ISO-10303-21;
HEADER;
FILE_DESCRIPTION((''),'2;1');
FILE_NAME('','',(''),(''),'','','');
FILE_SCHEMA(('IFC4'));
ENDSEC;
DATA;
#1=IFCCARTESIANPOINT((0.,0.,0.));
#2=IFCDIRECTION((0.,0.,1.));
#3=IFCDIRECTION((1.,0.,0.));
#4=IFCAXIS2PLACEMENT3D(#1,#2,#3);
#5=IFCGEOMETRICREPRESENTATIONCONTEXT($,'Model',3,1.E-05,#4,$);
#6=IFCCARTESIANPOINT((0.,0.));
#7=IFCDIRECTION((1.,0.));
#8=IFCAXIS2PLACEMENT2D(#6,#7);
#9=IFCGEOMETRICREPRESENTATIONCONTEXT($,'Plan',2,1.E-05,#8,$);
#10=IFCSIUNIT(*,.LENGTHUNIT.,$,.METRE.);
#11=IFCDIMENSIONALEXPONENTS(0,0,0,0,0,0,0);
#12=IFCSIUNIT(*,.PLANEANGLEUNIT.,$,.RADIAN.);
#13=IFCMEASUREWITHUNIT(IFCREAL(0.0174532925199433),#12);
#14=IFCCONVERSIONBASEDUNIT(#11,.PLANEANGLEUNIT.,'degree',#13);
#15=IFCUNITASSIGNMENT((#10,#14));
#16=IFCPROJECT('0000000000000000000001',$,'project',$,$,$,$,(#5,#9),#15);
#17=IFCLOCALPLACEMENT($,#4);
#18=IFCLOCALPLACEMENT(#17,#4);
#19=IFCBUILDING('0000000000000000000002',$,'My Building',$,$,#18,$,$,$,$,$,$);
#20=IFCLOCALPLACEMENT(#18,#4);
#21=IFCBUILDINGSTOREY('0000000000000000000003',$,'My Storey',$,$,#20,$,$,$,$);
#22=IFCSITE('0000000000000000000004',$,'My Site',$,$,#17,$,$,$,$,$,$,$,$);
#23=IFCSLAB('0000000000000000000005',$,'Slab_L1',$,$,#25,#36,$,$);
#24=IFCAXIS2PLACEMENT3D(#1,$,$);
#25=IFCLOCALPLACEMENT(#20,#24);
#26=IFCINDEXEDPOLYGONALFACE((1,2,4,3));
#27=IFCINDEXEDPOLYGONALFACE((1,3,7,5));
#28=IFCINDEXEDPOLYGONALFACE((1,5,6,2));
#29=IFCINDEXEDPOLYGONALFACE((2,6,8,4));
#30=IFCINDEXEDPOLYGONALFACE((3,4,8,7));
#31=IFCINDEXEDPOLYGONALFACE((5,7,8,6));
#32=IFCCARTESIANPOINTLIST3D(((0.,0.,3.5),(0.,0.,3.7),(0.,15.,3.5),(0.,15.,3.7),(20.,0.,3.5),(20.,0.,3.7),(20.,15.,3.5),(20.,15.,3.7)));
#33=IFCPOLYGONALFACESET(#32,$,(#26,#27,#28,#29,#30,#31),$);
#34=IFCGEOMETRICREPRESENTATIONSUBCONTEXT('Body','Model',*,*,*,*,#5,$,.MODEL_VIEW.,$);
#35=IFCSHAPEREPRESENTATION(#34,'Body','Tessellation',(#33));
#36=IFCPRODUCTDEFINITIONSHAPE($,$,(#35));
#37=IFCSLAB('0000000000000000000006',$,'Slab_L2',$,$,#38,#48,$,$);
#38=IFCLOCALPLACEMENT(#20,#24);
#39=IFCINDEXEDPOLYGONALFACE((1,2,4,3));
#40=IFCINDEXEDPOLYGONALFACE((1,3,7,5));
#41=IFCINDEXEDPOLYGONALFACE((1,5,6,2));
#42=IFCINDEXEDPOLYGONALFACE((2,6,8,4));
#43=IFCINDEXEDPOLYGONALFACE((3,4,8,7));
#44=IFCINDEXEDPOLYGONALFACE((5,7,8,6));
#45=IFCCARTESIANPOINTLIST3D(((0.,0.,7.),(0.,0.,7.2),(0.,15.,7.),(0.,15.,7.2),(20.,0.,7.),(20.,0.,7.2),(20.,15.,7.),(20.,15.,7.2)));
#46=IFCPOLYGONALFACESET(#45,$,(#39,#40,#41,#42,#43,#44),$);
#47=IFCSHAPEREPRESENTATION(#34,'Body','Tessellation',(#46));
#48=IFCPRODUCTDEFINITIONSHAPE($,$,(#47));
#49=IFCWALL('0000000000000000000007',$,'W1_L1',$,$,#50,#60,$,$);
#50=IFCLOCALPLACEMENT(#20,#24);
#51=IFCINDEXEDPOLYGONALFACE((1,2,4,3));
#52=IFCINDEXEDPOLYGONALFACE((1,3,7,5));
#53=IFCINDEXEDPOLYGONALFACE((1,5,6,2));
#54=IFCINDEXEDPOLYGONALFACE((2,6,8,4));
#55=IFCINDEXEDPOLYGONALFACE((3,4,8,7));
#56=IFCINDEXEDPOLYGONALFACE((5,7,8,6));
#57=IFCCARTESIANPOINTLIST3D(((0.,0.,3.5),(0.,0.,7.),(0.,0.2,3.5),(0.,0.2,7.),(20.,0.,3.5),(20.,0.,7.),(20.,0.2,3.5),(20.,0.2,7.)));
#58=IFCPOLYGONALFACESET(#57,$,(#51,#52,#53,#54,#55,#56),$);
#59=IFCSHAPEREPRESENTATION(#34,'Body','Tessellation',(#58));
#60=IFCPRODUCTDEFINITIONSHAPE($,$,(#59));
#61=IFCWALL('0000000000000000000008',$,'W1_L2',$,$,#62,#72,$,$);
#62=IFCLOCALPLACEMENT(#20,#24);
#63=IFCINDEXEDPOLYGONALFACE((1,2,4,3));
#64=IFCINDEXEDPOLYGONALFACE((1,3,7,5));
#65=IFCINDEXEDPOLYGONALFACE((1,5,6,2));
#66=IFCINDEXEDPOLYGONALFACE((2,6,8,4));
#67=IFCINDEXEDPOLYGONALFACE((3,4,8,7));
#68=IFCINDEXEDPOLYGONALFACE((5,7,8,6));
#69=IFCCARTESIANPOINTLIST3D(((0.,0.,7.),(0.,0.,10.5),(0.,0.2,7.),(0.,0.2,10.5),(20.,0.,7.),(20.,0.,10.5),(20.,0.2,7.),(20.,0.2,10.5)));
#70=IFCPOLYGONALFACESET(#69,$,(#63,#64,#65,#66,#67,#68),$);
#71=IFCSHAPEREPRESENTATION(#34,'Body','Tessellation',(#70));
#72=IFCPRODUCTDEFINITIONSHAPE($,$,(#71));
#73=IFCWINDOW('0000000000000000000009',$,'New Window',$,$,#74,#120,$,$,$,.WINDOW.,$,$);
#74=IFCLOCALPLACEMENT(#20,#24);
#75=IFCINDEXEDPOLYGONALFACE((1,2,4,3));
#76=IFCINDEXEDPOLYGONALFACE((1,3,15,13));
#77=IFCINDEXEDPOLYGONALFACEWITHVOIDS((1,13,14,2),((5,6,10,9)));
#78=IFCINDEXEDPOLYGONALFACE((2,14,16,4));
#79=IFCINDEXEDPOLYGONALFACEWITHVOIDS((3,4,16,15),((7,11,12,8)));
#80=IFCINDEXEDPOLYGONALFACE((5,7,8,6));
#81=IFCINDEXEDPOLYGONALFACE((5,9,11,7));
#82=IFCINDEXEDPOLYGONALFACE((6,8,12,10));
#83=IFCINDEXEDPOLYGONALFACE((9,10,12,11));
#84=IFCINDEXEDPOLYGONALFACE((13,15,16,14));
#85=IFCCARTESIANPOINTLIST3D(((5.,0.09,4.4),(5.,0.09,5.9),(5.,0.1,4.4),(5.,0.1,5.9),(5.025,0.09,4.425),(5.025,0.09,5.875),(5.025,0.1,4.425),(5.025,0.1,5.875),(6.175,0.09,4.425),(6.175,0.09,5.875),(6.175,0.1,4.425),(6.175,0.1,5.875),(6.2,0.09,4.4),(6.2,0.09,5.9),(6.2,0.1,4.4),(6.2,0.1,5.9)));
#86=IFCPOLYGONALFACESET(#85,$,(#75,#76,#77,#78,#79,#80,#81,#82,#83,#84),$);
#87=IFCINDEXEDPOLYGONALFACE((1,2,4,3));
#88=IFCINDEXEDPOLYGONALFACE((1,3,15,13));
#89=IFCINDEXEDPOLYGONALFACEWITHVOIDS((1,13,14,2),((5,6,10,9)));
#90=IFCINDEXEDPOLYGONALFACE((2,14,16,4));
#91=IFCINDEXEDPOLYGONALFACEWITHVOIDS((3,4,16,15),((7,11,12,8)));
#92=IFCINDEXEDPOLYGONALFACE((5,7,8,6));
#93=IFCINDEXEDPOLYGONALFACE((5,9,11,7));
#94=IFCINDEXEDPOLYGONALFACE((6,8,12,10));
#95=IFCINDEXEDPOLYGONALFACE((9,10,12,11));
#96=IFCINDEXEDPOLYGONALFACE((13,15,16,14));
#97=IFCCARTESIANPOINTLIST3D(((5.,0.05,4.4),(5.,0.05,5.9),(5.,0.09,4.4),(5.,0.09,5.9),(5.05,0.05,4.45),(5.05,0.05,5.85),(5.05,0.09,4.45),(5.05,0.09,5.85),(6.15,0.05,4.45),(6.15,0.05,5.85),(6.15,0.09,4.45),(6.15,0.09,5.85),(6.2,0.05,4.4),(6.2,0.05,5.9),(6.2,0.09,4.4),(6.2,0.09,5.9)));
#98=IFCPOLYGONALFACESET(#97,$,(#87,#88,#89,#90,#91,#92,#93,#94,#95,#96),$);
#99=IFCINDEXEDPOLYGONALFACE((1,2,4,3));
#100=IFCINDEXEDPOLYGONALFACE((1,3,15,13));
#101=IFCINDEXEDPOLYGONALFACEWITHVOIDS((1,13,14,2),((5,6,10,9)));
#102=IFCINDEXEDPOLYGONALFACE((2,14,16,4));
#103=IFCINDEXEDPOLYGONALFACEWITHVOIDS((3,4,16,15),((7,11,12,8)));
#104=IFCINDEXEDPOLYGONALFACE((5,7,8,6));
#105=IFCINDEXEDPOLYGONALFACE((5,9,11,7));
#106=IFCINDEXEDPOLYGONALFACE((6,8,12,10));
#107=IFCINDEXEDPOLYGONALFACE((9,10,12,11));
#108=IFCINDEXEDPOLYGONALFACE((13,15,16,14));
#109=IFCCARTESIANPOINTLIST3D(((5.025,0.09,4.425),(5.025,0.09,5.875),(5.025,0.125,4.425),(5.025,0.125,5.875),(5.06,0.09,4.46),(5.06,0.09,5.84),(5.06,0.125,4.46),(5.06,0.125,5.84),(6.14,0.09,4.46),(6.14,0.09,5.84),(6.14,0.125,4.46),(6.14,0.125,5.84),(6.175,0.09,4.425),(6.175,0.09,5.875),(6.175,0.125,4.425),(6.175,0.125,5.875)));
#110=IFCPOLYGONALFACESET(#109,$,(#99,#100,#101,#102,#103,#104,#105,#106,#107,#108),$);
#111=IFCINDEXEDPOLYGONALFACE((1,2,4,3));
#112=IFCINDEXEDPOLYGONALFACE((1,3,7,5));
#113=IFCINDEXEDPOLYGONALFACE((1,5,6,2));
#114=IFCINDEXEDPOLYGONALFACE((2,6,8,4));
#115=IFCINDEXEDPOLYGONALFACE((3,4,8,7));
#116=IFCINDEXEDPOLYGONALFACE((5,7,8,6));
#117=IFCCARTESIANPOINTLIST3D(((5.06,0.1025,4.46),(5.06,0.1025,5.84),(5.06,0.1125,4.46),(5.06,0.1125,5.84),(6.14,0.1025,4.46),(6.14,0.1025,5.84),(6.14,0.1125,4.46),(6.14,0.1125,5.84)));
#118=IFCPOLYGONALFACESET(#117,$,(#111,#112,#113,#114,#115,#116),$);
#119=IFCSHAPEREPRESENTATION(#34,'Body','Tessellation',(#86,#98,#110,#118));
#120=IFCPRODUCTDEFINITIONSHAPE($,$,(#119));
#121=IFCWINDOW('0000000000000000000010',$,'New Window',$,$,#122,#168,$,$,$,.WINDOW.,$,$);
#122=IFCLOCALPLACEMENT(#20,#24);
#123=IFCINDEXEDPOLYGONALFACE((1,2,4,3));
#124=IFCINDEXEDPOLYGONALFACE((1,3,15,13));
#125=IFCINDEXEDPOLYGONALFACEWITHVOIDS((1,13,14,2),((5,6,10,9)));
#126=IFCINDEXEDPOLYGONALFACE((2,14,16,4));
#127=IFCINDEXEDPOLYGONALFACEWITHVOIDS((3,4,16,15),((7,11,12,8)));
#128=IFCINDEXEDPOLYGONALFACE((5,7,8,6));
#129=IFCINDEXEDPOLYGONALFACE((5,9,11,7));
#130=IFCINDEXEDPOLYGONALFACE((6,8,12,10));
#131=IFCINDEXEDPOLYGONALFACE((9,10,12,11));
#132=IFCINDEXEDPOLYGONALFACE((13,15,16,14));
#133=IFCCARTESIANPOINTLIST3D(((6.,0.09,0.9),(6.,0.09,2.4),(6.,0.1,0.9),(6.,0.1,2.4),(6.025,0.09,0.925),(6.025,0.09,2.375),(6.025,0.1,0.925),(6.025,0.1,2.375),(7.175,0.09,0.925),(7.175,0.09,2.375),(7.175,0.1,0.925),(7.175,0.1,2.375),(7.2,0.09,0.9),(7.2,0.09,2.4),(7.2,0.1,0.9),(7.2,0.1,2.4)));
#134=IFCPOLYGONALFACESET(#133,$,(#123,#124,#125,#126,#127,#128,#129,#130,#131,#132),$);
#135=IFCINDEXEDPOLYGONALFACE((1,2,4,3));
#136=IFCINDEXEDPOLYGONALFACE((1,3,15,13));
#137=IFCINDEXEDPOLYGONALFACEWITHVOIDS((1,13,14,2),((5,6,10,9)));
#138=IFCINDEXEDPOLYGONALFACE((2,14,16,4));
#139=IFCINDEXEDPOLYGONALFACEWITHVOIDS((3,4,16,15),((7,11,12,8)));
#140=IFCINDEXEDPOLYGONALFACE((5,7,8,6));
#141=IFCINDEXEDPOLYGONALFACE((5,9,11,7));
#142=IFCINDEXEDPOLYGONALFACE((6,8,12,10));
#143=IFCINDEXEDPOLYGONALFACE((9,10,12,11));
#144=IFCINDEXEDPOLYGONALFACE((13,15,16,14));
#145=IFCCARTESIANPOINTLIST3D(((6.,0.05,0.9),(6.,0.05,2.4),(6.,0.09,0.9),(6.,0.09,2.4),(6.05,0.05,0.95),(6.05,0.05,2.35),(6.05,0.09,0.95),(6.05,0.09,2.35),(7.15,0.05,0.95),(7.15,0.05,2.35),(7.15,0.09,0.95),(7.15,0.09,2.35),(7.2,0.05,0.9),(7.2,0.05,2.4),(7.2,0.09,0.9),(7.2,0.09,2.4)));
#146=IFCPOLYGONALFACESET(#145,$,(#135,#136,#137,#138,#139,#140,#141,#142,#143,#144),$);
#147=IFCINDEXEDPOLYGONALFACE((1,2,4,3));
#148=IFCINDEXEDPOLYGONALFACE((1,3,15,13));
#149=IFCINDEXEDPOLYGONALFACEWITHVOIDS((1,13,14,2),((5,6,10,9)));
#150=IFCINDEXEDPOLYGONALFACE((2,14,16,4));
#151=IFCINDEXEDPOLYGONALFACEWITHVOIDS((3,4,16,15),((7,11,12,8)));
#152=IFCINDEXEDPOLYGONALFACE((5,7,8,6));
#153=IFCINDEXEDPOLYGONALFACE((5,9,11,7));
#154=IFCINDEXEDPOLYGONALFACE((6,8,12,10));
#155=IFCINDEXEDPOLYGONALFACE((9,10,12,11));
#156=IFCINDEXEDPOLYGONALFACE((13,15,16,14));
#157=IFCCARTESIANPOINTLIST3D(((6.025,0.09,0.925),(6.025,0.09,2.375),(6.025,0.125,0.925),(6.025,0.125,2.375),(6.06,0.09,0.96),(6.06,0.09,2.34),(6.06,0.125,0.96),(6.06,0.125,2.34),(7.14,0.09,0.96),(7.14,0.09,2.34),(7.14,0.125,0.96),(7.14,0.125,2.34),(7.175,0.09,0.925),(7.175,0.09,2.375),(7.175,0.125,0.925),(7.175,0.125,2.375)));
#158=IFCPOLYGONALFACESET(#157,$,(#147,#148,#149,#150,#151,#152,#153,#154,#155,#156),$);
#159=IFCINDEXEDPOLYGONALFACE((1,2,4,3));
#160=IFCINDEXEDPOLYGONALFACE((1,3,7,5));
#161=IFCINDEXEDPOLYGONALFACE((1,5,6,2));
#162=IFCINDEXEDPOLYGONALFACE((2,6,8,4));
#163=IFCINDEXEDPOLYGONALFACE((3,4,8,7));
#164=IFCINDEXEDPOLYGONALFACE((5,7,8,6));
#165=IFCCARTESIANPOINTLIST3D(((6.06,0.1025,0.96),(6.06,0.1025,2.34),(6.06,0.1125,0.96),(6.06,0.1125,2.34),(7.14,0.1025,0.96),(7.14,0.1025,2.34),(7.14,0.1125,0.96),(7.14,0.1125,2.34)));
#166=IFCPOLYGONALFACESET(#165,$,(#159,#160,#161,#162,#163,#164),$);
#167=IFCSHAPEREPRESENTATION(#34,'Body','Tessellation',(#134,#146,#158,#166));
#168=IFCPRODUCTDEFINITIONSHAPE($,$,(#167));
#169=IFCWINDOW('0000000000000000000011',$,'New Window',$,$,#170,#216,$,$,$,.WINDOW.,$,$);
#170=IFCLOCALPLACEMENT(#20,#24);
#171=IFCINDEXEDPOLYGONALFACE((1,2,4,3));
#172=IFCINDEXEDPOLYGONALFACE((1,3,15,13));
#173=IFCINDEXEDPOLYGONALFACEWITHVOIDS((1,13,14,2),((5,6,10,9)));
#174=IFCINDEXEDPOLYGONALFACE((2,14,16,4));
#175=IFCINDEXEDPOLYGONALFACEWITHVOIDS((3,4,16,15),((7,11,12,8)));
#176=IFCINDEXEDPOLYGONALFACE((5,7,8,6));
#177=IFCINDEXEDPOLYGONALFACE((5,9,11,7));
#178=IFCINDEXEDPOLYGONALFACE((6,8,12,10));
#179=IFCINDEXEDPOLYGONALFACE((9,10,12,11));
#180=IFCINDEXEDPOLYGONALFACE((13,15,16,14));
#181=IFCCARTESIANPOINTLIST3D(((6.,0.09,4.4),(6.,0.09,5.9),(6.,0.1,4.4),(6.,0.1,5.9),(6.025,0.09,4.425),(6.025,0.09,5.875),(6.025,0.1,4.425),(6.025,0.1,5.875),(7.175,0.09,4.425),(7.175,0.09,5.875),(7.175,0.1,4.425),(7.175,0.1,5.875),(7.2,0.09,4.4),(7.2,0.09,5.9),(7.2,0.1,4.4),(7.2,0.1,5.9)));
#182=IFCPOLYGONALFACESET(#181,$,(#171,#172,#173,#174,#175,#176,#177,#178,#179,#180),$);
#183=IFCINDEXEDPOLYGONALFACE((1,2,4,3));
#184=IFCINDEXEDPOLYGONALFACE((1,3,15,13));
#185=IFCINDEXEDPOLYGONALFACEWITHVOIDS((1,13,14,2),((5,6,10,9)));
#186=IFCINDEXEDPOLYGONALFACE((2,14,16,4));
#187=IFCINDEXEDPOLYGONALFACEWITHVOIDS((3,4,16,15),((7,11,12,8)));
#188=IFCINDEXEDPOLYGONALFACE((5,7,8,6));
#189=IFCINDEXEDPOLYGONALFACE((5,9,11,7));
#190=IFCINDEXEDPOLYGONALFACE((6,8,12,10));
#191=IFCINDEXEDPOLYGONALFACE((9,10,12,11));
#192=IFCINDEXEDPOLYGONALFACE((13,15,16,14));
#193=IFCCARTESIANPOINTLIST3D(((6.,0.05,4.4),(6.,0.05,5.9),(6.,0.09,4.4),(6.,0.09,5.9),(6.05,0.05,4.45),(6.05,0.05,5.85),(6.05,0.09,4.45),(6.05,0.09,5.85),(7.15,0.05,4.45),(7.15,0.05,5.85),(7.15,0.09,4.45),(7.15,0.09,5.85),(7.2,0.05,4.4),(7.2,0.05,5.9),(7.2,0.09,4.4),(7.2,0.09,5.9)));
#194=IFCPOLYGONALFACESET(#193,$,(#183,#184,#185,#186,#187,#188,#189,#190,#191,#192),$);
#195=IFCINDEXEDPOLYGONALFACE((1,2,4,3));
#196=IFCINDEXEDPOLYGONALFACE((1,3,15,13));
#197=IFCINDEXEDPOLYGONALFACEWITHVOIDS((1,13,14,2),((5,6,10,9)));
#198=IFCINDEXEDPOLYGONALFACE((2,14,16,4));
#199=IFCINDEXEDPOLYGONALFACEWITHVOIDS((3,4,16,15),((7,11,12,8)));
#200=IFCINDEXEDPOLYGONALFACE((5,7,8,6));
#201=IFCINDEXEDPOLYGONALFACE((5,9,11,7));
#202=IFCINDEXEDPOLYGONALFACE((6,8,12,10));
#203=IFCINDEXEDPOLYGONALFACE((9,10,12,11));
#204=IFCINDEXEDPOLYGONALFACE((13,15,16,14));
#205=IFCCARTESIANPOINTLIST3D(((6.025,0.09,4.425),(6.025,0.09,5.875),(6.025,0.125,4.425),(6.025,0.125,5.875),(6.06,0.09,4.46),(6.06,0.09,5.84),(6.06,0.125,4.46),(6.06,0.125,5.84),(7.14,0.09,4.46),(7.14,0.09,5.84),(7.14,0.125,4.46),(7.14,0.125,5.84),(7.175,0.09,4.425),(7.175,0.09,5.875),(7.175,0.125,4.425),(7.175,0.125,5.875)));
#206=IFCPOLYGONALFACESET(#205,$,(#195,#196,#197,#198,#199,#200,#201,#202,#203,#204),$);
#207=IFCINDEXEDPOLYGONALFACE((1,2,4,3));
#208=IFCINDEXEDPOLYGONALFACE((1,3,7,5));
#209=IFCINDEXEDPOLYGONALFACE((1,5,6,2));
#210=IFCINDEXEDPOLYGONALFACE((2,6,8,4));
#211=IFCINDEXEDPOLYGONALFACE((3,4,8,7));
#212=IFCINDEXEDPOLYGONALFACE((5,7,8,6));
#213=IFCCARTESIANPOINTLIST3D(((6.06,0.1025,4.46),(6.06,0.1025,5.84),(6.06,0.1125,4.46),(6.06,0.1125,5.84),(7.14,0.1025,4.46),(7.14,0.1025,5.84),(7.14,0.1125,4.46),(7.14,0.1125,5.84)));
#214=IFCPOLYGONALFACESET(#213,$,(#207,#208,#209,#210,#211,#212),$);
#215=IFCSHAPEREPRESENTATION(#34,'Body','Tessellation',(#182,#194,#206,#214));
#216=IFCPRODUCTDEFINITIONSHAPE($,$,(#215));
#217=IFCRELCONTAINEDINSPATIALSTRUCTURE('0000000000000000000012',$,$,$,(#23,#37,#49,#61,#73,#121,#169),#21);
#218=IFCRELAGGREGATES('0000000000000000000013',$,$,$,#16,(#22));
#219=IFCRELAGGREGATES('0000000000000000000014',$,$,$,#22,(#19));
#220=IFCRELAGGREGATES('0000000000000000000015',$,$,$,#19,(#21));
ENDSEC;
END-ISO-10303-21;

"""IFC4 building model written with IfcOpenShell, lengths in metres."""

from ifc_helpers import new_model, entity, si_unit, converted_unit, frame, origin_with_axes, origin_2d_with_axis, place, context, subcontext, project, spatial, line, indexed_curve, outline, extrude, element, save


model = new_model("IFC4")

# Units and contexts
model_context = context("Model", 3, precision=1e-05, world=origin_with_axes())
plan_context = context("Plan", 2, precision=1e-05, world=origin_2d_with_axis())
body_context = subcontext(model_context, "Body", "Model", "MODEL_VIEW")
ifc_project = project(units=[si_unit("LENGTHUNIT", "METRE"), converted_unit("PLANEANGLEUNIT", "degree", entity("IfcReal", 0.0174532925199433), si_unit("PLANEANGLEUNIT", "RADIAN"), dimensions=[0, 0, 0, 0, 0, 0, 0])], contexts=[model_context, plan_context])

# Site, building, storey
site_placement = place(None, origin_with_axes())
site = spatial("IfcSite", under=ifc_project, at=site_placement, Name="My Site")
building_placement = place(site_placement, origin_with_axes())
building = spatial("IfcBuilding", under=site, at=building_placement, Name="My Building")
storey_placement = place(building_placement, origin_with_axes())
storey = spatial("IfcBuildingStorey", under=building, at=storey_placement, Name="My Storey")

# Slabs
for number, where, z_axis, x_axis, name in (
    (1, (0.0, 0.0, 3.5), (0.0, 0.0, 1.0), (1.0, 0.0, 0.0), "Slab_L1"),
    (2, (0.0, 0.0, 7.0), (0.0, 0.0, 1.0), (1.0, 0.0, 0.0), "Slab_L2"),
):
    element("IfcSlab", number, at=place(storey_placement, frame(where, z_axis=z_axis, x_axis=x_axis)), inside=storey, Name=name, context=body_context, shape_type="SweptSolid", body=[
        extrude(outline(indexed_curve([(0.0, 0.0), (20.0, 0.0), (20.0, 15.0), (0.0, 15.0), (0.0, 0.0)])), None, (0.0, 0.0, 1.0), 0.2),
    ])

# Walls
for number, where, z_axis, x_axis, name in (
    (3, (0.0, 0.0, 3.5), (0.0, 0.0, 1.0), (1.0, 0.0, 0.0), "W1_L1"),
    (4, (0.0, 0.0, 7.0), (0.0, 0.0, 1.0), (1.0, 0.0, 0.0), "W1_L2"),
):
    element("IfcWall", number, at=place(storey_placement, frame(where, z_axis=z_axis, x_axis=x_axis)), inside=storey, Name=name, context=body_context, shape_type="SweptSolid", body=[
        extrude(outline(indexed_curve([(0.0, 0.0), (0.0, 0.2), (20.0, 0.2), (20.0, 0.0), (0.0, 0.0)], self_intersect=False)), origin_with_axes(), (0.0, 0.0, 1.0), 3.5),
    ])

# Window
window_placement = place(storey_placement, frame((5.0, 0.0, 4.4), z_axis=(0.0, 0.0, 1.0), x_axis=(1.0, 0.0, 0.0)))
element("IfcWindow", 5, at=window_placement, inside=storey, Name="New Window", PredefinedType="WINDOW", context=body_context, shape_type="SweptSolid", body=[
    extrude(outline(indexed_curve([(0.0, 0.0), (1.2, 0.0), (1.2, 1.5), (0.0, 1.5)], segments=[line(1, 2, 3, 4, 1)]), holes=[indexed_curve([(0.025, 0.025), (1.175, 0.025), (1.175, 1.475), (0.025, 1.475)], segments=[line(1, 2, 3, 4, 1)])]), frame((0.0, 0.09, 0.0), z_axis=(0.0, -1.0, 0.0), x_axis=(1.0, 0.0, 0.0)), (0.0, 0.0, -1.0), 0.01),
    extrude(outline(indexed_curve([(0.0, 0.0), (1.2, 0.0), (1.2, 1.5), (0.0, 1.5)], segments=[line(1, 2, 3, 4, 1)]), holes=[indexed_curve([(0.05, 0.05), (1.15, 0.05), (1.15, 1.45), (0.05, 1.45)], segments=[line(1, 2, 3, 4, 1)])]), frame((0.0, 0.05, 0.0), z_axis=(0.0, -1.0, 0.0), x_axis=(1.0, 0.0, 0.0)), (0.0, 0.0, -1.0), 0.04),
    extrude(outline(indexed_curve([(0.0, 0.0), (1.15, 0.0), (1.15, 1.45), (0.0, 1.45)], segments=[line(1, 2, 3, 4, 1)]), holes=[indexed_curve([(0.035, 0.035), (1.115, 0.035), (1.115, 1.415), (0.035, 1.415)], segments=[line(1, 2, 3, 4, 1)])]), frame((0.025, 0.09, 0.025), z_axis=(0.0, -1.0, 0.0), x_axis=(1.0, 0.0, 0.0)), (0.0, 0.0, -1.0), 0.035),
    extrude(outline(indexed_curve([(0.035, 0.035), (1.115, 0.035), (1.115, 1.415), (0.035, 1.415)], segments=[line(1, 2, 3, 4, 1)])), frame((0.025, 0.1025, 0.025), z_axis=(0.0, -1.0, 0.0), x_axis=(1.0, 0.0, 0.0)), (0.0, 0.0, -1.0), 0.01),
])

# Windows
for number, where, z_axis, x_axis, name in (
    (6, (6.0, 0.0, 0.9), (0.0, 0.0, 1.0), (1.0, 0.0, 0.0), "New Window"),
    (7, (6.0, 0.0, 4.4), (0.0, 0.0, 1.0), (1.0, 0.0, 0.0), "New Window"),
):
    element("IfcWindow", number, at=place(storey_placement, frame(where, z_axis=z_axis, x_axis=x_axis)), inside=storey, Name=name, PredefinedType="WINDOW", context=body_context, shape_type="SweptSolid", body=[
        extrude(outline(indexed_curve([(0.0, 0.0), (1.2, 0.0), (1.2, 1.5), (0.0, 1.5)], segments=[line(1, 2, 3, 4, 1)]), holes=[indexed_curve([(0.025, 0.025), (1.175, 0.025), (1.175, 1.475), (0.025, 1.475)], segments=[line(1, 2, 3, 4, 1)])]), frame((0.0, 0.09, 0.0), z_axis=(0.0, -1.0, 0.0), x_axis=(1.0, 0.0, 0.0)), (0.0, 0.0, -1.0), 0.01),
        extrude(outline(indexed_curve([(0.0, 0.0), (1.2, 0.0), (1.2, 1.5), (0.0, 1.5)], segments=[line(1, 2, 3, 4, 1)]), holes=[indexed_curve([(0.05, 0.05), (1.15, 0.05), (1.15, 1.45), (0.05, 1.45)], segments=[line(1, 2, 3, 4, 1)])]), frame((0.0, 0.05, 0.0), z_axis=(0.0, -1.0, 0.0), x_axis=(1.0, 0.0, 0.0)), (0.0, 0.0, -1.0), 0.04),
        extrude(outline(indexed_curve([(0.0, 0.0), (1.15, 0.0), (1.15, 1.45), (0.0, 1.45)], segments=[line(1, 2, 3, 4, 1)]), holes=[indexed_curve([(0.035, 0.035), (1.115, 0.035), (1.115, 1.415), (0.035, 1.415)], segments=[line(1, 2, 3, 4, 1)])]), frame((0.025, 0.09, 0.025), z_axis=(0.0, -1.0, 0.0), x_axis=(1.0, 0.0, 0.0)), (0.0, 0.0, -1.0), 0.035),
        extrude(outline(indexed_curve([(0.035, 0.035), (1.115, 0.035), (1.115, 1.415), (0.035, 1.415)], segments=[line(1, 2, 3, 4, 1)])), frame((0.025, 0.1025, 0.025), z_axis=(0.0, -1.0, 0.0), x_axis=(1.0, 0.0, 0.0)), (0.0, 0.0, -1.0), 0.01),
    ])

save(model, "model.ifc")
